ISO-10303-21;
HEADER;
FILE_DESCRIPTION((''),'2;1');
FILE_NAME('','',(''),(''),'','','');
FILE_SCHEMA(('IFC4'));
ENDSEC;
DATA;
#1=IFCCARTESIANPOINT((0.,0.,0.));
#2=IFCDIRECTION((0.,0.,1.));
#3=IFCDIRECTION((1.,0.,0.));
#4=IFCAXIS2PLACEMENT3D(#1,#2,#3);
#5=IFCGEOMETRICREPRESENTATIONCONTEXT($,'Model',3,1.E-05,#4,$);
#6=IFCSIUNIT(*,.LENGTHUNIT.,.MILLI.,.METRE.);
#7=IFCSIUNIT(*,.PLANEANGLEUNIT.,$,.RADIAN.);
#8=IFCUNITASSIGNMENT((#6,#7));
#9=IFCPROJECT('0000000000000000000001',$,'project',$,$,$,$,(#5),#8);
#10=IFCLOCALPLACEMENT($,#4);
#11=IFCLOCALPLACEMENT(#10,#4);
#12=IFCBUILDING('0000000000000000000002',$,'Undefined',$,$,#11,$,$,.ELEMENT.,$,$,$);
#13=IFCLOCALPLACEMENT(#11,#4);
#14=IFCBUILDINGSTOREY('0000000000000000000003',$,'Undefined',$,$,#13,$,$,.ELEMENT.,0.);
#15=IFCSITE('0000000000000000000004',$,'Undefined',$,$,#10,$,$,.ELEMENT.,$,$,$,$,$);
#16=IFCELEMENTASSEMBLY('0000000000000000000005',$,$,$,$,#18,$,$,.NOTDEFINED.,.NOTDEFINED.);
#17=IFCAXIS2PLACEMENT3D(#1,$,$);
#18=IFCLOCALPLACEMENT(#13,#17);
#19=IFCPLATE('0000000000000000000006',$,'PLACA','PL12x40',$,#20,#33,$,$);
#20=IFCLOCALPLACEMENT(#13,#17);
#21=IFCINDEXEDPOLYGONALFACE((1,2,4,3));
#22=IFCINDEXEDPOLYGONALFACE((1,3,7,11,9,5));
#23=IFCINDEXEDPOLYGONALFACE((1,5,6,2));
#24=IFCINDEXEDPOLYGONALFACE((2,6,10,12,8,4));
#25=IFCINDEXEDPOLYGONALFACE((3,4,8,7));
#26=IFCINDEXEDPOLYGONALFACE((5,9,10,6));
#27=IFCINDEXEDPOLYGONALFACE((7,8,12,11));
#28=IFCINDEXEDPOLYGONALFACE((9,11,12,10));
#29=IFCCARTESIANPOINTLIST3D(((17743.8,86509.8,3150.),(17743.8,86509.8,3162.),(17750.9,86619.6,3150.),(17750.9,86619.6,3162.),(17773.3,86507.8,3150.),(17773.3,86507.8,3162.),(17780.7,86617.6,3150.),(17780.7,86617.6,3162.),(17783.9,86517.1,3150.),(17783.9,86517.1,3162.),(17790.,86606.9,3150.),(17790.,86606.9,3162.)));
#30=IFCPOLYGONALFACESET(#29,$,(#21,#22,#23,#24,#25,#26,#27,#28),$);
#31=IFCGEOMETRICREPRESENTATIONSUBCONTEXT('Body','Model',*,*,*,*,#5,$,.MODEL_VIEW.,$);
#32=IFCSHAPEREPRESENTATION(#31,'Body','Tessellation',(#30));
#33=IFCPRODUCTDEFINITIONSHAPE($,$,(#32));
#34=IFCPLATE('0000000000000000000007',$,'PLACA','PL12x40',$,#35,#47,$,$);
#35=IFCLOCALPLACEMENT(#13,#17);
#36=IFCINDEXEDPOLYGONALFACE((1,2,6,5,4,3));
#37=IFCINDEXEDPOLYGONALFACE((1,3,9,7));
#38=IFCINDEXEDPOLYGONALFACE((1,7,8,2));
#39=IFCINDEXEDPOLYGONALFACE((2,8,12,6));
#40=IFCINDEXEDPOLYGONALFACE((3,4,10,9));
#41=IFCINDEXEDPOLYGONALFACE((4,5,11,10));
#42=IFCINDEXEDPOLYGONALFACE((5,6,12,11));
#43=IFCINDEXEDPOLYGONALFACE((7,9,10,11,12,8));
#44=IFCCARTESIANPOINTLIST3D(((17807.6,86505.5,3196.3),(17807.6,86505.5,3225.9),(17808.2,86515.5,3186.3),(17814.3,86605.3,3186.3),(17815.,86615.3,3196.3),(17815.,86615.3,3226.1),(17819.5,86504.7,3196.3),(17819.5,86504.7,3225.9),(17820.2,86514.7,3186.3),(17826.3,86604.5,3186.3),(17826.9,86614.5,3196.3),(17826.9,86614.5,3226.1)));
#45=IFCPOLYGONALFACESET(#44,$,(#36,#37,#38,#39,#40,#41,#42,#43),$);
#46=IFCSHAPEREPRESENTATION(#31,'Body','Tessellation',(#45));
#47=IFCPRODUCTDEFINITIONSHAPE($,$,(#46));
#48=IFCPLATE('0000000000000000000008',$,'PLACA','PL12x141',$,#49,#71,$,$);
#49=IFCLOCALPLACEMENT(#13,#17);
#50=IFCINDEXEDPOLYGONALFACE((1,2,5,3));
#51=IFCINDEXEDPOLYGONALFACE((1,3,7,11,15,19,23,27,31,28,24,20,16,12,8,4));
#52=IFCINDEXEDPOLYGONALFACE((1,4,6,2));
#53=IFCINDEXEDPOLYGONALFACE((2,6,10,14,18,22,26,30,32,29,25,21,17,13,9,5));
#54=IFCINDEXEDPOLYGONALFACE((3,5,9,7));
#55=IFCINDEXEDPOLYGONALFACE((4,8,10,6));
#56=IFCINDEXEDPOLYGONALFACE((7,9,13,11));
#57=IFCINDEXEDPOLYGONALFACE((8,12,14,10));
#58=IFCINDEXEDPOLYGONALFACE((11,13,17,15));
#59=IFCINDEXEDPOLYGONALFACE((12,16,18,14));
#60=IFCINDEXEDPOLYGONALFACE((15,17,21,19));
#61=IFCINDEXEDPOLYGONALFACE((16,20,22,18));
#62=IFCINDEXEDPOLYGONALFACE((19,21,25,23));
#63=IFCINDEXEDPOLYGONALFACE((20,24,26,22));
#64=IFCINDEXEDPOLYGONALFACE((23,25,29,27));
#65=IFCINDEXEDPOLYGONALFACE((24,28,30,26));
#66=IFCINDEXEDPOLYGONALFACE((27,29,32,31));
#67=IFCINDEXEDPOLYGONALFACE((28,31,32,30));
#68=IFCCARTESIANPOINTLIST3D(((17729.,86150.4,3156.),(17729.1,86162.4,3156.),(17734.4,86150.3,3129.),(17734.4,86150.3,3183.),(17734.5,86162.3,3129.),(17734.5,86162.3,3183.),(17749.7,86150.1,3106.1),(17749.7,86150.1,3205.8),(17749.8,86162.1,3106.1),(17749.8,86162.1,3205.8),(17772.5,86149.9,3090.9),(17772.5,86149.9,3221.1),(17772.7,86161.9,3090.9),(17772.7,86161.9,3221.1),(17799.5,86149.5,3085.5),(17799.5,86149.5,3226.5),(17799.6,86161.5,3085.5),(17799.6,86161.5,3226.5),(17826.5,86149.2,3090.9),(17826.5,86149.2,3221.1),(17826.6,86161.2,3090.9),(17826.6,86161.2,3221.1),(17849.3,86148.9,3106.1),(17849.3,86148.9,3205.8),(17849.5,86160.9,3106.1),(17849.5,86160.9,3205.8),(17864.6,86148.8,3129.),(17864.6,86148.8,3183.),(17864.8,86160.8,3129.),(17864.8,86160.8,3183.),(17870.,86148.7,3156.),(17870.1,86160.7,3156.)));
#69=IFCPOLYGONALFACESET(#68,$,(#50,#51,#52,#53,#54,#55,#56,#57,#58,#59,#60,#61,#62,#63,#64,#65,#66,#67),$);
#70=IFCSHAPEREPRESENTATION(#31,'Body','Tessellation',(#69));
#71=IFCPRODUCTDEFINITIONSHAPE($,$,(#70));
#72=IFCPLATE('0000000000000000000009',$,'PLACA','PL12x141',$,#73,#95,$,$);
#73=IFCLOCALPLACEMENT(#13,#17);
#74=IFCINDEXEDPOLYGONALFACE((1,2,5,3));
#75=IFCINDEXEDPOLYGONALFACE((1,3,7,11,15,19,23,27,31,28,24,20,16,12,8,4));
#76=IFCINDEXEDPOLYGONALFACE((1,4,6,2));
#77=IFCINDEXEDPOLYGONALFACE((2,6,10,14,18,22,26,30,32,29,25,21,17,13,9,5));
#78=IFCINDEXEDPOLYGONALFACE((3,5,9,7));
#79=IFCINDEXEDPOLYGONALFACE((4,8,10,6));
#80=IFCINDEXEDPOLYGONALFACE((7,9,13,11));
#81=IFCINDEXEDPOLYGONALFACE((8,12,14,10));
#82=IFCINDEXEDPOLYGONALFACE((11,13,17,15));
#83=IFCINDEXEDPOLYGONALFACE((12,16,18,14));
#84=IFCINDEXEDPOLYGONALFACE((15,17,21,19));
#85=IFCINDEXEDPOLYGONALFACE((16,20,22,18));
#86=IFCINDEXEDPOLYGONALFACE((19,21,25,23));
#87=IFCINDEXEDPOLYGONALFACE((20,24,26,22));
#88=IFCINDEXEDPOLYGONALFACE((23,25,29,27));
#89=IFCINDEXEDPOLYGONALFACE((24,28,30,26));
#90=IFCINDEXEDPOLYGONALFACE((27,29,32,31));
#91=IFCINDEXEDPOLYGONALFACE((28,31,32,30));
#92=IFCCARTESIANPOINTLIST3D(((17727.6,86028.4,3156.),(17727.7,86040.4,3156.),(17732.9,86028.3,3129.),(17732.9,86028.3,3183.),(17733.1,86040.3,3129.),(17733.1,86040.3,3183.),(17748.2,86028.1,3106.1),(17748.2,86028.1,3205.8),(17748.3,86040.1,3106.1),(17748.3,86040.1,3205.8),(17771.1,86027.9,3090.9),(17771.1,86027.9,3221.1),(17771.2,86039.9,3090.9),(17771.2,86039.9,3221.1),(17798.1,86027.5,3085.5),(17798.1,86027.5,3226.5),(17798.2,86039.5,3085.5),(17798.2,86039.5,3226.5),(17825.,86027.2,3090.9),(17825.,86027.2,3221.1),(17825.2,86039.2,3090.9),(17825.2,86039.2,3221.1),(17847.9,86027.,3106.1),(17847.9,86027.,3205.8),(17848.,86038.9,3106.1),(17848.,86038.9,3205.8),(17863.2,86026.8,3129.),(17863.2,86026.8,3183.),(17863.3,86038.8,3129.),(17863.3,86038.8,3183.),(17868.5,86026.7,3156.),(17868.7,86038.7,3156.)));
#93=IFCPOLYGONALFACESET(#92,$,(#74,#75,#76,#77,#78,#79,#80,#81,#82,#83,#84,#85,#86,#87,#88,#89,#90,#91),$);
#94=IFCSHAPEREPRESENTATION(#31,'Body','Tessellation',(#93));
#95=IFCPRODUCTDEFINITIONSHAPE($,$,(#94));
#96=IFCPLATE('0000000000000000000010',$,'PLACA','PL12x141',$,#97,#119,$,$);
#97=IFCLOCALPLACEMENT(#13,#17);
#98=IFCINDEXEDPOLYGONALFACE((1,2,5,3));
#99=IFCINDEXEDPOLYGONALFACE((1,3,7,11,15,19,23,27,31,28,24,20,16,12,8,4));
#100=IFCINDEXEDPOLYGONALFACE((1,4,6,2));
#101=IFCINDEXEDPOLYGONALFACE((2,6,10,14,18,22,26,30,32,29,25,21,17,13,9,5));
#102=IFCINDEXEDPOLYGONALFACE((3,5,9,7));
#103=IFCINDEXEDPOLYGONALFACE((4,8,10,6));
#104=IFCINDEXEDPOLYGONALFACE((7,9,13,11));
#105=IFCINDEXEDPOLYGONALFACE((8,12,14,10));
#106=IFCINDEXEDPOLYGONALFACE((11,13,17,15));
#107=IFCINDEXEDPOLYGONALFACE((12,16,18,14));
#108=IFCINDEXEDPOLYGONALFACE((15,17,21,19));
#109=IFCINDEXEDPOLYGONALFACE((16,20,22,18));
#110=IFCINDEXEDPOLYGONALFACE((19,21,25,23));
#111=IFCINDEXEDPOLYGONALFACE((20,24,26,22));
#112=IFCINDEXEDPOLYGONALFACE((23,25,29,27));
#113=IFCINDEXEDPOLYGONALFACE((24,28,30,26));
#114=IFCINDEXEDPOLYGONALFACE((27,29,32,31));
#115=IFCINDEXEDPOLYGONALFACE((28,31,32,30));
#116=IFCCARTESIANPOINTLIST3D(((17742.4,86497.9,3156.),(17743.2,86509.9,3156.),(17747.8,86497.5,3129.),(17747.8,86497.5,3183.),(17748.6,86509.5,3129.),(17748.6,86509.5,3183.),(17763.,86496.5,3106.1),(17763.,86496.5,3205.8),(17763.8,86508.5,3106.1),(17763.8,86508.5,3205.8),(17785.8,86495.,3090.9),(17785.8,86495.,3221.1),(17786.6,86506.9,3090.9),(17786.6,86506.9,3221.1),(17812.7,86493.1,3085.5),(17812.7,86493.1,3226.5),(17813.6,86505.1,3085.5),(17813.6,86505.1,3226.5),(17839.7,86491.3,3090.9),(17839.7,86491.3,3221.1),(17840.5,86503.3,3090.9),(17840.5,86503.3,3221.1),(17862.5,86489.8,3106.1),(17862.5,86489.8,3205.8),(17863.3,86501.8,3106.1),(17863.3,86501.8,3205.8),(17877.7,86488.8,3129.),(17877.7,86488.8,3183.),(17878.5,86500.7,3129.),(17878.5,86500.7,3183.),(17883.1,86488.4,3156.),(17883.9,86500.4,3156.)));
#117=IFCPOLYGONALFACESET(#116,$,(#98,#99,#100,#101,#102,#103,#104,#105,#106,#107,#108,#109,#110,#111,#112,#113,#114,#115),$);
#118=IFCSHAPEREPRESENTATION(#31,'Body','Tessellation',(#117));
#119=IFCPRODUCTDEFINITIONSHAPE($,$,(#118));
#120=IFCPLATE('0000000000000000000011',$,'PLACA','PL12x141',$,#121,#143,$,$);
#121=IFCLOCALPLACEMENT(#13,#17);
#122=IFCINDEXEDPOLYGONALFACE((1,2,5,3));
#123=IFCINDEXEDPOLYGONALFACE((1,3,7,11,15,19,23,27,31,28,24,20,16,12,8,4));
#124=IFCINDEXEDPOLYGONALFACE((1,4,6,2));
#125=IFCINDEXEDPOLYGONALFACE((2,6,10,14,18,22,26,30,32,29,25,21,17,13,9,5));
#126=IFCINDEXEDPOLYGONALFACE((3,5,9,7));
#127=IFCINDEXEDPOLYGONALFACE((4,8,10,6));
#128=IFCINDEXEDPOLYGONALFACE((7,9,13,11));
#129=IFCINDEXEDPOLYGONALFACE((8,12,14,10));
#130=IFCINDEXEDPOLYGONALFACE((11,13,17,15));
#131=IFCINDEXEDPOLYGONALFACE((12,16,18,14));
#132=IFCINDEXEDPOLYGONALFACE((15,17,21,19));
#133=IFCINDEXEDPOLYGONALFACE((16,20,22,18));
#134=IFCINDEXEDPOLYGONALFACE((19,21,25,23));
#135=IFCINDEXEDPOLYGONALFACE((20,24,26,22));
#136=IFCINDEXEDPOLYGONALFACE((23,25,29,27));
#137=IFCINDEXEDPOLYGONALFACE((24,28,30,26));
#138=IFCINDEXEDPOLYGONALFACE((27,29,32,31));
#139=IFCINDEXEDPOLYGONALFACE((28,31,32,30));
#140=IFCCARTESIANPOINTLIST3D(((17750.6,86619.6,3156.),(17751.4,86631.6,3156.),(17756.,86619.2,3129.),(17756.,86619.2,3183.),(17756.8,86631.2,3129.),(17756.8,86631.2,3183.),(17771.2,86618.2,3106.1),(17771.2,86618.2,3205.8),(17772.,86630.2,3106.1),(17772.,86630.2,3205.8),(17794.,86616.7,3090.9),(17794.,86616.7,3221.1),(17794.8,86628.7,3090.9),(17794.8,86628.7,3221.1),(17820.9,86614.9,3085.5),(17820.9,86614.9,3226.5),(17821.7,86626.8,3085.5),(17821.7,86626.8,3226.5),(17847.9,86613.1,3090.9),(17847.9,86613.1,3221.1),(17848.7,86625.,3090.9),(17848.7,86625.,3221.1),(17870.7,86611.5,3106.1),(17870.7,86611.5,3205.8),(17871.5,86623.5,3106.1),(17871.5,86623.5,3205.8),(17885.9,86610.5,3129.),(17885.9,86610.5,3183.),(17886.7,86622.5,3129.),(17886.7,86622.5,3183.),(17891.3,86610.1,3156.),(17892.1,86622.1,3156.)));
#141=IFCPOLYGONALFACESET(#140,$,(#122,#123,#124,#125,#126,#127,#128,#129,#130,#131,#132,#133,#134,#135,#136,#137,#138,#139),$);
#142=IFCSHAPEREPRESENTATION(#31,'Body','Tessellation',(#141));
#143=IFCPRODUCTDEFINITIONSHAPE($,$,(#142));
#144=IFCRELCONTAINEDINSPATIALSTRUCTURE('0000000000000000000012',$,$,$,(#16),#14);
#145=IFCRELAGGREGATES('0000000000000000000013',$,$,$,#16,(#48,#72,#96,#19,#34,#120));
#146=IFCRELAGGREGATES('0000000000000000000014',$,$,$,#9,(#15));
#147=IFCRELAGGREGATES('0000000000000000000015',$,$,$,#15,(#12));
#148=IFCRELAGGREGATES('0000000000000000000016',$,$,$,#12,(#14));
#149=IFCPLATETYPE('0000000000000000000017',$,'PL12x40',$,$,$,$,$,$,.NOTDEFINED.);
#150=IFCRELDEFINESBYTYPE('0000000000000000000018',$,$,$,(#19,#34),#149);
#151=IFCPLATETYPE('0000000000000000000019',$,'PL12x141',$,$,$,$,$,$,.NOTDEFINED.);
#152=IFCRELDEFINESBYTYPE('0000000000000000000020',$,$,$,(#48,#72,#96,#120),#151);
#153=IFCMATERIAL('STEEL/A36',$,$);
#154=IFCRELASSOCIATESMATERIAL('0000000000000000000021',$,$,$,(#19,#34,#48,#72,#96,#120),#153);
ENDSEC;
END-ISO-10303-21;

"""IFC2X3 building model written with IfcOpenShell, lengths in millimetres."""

from ifc_helpers import new_model, si_unit, frame, origin_with_axes, place, context, subcontext, project, spatial, polyline, outline, extrude, material, type_object, element, aggregate, save


model = new_model("IFC2X3")

# Units and contexts
model_context = context("Model", 3, precision=1e-05, world=origin_with_axes())
body_context = subcontext(model_context, "Body", "Model", "MODEL_VIEW")
ifc_project = project(units=[si_unit("LENGTHUNIT", "METRE", prefix="MILLI"), si_unit("PLANEANGLEUNIT", "RADIAN")], contexts=[model_context])

# Site, building, storey
site_placement = place(None, origin_with_axes())
site = spatial("IfcSite", under=ifc_project, at=site_placement, Name="Undefined", CompositionType="ELEMENT")
building_placement = place(site_placement, origin_with_axes())
building = spatial("IfcBuilding", under=site, at=building_placement, Name="Undefined", CompositionType="ELEMENT")
storey_placement = place(building_placement, origin_with_axes())
storey = spatial("IfcBuildingStorey", under=building, at=storey_placement, Name="Undefined", CompositionType="ELEMENT", Elevation=0.0)

# Element assembly, plates
assembly_placement = place(storey_placement, origin_with_axes())
assembly = element("IfcElementAssembly", 1, at=assembly_placement, inside=storey, AssemblyPlace="NOTDEFINED", PredefinedType="NOTDEFINED")
ifc_material_1 = material(Name="STEEL/A36")
plate_type_1 = type_object("IfcPlateType", Name="PL12x40", PredefinedType="NOTDEFINED")
plate_1_placement = place(assembly_placement, frame((17750.9, 86619.6, 3156.0), z_axis=(0.0, 0.0, -1.0), x_axis=(0.997745, -0.067123, 0.0)))
plate_1 = element("IfcPlate", 2, at=plate_1_placement, type_object=plate_type_1, material=ifc_material_1, Name="PLACA", Description="PL12x40", context=body_context, shape_type="SweptSolid", body=[
    extrude(outline(polyline([(0.0, 0.0), (29.8, 0.0), (39.8, 10.0), (39.8, 100.0), (29.8, 110.0), (0.2, 110.0), (0.0, 0.0)])), frame((0.0, 0.0, -6.0), z_axis=(0.0, 0.0, 1.0), x_axis=(1.0, 0.0, 0.0)), (0.0, 0.0, 1.0), 12.0),
])
plate_2_placement = place(assembly_placement, frame((17820.9, 86614.9, 3226.1), z_axis=(-0.997745, 0.067123, 0.0), x_axis=(0.0, 0.0, -1.0)))
plate_2 = element("IfcPlate", 3, at=plate_2_placement, type_object=plate_type_1, material=ifc_material_1, Name="PLACA", Description="PL12x40", context=body_context, shape_type="SweptSolid", body=[
    extrude(outline(polyline([(0.0, 0.0), (29.8, 0.0), (39.8, 10.0), (39.8, 100.0), (29.8, 110.0), (0.2, 110.0), (0.0, 0.0)])), frame((0.0, 0.0, -6.0), z_axis=(0.0, 0.0, 1.0), x_axis=(1.0, 0.0, 0.0)), (0.0, 0.0, 1.0), 12.0),
])
plate_type_2 = type_object("IfcPlateType", Name="PL12x141", PredefinedType="NOTDEFINED")
plate_3_placement = place(assembly_placement, frame((17729.1, 86156.4, 3226.5), z_axis=(0.011839, 0.99993, 0.0), x_axis=(0.99993, -0.011839, 0.0)))
plate_3 = element("IfcPlate", 4, at=plate_3_placement, type_object=plate_type_2, material=ifc_material_1, Name="PLACA", Description="PL12x141", context=body_context, shape_type="SweptSolid", body=[
    extrude(outline(polyline([(0.0, 70.5), (5.4, 43.5), (20.6, 20.6), (43.5, 5.4), (70.5, 0.0), (70.5, 0.0), (97.5, 5.4), (120.4, 20.6), (135.6, 43.5), (141.0, 70.5), (141.0, 70.5), (135.6, 97.5), (120.4, 120.4), (97.5, 135.6), (70.5, 141.0), (70.5, 141.0), (43.5, 135.6), (20.6, 120.4), (5.4, 97.5), (0.0, 70.5), (0.0, 70.5)])), frame((0.0, 0.0, -6.0), z_axis=(0.0, 0.0, 1.0), x_axis=(1.0, 0.0, 0.0)), (0.0, 0.0, 1.0), 12.0),
])
plate_4_placement = place(assembly_placement, frame((17727.6, 86034.4, 3226.5), z_axis=(0.011839, 0.99993, 0.0), x_axis=(0.99993, -0.011839, 0.0)))
plate_4 = element("IfcPlate", 5, at=plate_4_placement, type_object=plate_type_2, material=ifc_material_1, Name="PLACA", Description="PL12x141", context=body_context, shape_type="SweptSolid", body=[
    extrude(outline(polyline([(0.0, 70.5), (5.4, 43.5), (20.6, 20.6), (43.5, 5.4), (70.5, 0.0), (70.5, 0.0), (97.5, 5.4), (120.4, 20.6), (135.6, 43.5), (141.0, 70.5), (141.0, 70.5), (135.6, 97.5), (120.4, 120.4), (97.5, 135.6), (70.5, 141.0), (70.5, 141.0), (43.5, 135.6), (20.6, 120.4), (5.4, 97.5), (0.0, 70.5), (0.0, 70.5)])), frame((0.0, 0.0, -6.0), z_axis=(0.0, 0.0, 1.0), x_axis=(1.0, 0.0, 0.0)), (0.0, 0.0, 1.0), 12.0),
])
plate_5_placement = place(assembly_placement, frame((17883.5, 86494.4, 3226.5), z_axis=(-0.067123, -0.997745, 0.0), x_axis=(-0.997745, 0.067123, 0.0)))
plate_5 = element("IfcPlate", 6, at=plate_5_placement, type_object=plate_type_2, material=ifc_material_1, Name="PLACA", Description="PL12x141", context=body_context, shape_type="SweptSolid", body=[
    extrude(outline(polyline([(0.0, 70.5), (5.4, 43.5), (20.6, 20.6), (43.5, 5.4), (70.5, 0.0), (70.5, 0.0), (97.5, 5.4), (120.4, 20.6), (135.6, 43.5), (141.0, 70.5), (141.0, 70.5), (135.6, 97.5), (120.4, 120.4), (97.5, 135.6), (70.5, 141.0), (70.5, 141.0), (43.5, 135.6), (20.6, 120.4), (5.4, 97.5), (0.0, 70.5), (0.0, 70.5)])), frame((0.0, 0.0, -6.0), z_axis=(0.0, 0.0, 1.0), x_axis=(1.0, 0.0, 0.0)), (0.0, 0.0, 1.0), 12.0),
])
plate_6_placement = place(assembly_placement, frame((17891.7, 86616.1, 3226.5), z_axis=(-0.067123, -0.997745, 0.0), x_axis=(-0.997745, 0.067123, 0.0)))
plate_6 = element("IfcPlate", 7, at=plate_6_placement, type_object=plate_type_2, material=ifc_material_1, Name="PLACA", Description="PL12x141", context=body_context, shape_type="SweptSolid", body=[
    extrude(outline(polyline([(0.0, 70.5), (5.4, 43.5), (20.6, 20.6), (43.5, 5.4), (70.5, 0.0), (70.5, 0.0), (97.5, 5.4), (120.4, 20.6), (135.6, 43.5), (141.0, 70.5), (141.0, 70.5), (135.6, 97.5), (120.4, 120.4), (97.5, 135.6), (70.5, 141.0), (70.5, 141.0), (43.5, 135.6), (20.6, 120.4), (5.4, 97.5), (0.0, 70.5), (0.0, 70.5)])), frame((0.0, 0.0, -6.0), z_axis=(0.0, 0.0, 1.0), x_axis=(1.0, 0.0, 0.0)), (0.0, 0.0, 1.0), 12.0),
])
aggregate(assembly, [plate_3, plate_4, plate_5, plate_1, plate_2, plate_6])

save(model, "model.ifc")
